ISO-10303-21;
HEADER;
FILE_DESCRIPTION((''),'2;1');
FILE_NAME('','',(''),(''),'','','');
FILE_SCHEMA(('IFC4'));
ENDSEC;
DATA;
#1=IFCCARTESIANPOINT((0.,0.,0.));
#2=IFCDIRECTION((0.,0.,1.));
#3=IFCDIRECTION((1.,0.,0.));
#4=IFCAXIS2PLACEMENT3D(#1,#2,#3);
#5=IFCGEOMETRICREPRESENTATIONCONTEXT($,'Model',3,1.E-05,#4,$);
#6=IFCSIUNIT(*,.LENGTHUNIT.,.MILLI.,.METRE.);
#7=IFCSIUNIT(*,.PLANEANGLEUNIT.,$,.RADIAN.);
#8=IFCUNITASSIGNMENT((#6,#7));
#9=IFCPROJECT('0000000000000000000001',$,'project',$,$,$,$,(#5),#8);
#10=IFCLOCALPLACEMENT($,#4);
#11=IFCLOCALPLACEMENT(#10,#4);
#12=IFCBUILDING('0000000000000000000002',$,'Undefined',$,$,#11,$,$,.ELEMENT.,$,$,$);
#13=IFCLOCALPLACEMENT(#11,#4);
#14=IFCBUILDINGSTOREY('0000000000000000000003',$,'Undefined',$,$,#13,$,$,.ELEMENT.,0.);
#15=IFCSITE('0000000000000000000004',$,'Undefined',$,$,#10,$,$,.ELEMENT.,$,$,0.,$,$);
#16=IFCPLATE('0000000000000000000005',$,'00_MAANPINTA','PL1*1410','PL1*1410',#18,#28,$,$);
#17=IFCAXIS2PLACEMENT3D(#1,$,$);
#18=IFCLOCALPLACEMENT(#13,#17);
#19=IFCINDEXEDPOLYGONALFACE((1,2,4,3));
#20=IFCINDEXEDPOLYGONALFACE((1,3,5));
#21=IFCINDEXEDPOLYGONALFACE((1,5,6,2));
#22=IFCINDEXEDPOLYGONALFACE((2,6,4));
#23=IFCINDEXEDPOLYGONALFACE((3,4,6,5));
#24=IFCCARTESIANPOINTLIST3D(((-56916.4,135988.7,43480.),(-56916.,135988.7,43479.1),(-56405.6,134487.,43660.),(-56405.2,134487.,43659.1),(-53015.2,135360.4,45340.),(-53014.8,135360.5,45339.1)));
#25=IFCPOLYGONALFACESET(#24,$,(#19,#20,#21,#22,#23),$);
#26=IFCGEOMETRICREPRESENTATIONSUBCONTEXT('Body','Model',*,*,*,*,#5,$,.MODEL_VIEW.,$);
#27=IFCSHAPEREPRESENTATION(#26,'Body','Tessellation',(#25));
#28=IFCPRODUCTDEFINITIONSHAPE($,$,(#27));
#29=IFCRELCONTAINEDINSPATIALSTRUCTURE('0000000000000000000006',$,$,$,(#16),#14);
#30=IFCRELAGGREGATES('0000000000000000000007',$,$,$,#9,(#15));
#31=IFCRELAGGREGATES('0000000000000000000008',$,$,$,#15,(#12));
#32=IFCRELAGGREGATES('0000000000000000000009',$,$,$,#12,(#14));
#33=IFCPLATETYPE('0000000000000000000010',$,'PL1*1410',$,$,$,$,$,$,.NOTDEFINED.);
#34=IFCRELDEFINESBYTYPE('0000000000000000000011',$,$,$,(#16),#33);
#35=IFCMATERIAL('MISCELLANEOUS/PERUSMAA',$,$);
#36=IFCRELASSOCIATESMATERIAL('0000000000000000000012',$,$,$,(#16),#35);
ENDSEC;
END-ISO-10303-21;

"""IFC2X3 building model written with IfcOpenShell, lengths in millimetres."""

from ifc_helpers import new_model, si_unit, frame, origin_with_axes, place, context, subcontext, project, spatial, polyline, outline, extrude, material, type_object, element, save


model = new_model("IFC2X3")

# Units and contexts
model_context = context("Model", 3, precision=1e-05, world=origin_with_axes())
body_context = subcontext(model_context, "Body", "Model", "MODEL_VIEW")
ifc_project = project(units=[si_unit("LENGTHUNIT", "METRE", prefix="MILLI"), si_unit("PLANEANGLEUNIT", "RADIAN")], contexts=[model_context])

# Site, building, storey
site_placement = place(None, origin_with_axes())
site = spatial("IfcSite", under=ifc_project, at=site_placement, Name="Undefined", CompositionType="ELEMENT", RefElevation=0.0)
building_placement = place(site_placement, origin_with_axes())
building = spatial("IfcBuilding", under=site, at=building_placement, Name="Undefined", CompositionType="ELEMENT")
storey_placement = place(building_placement, origin_with_axes())
storey = spatial("IfcBuildingStorey", under=building, at=storey_placement, Name="Undefined", CompositionType="ELEMENT", Elevation=0.0)

# Plate
ifc_material = material(Name="MISCELLANEOUS/PERUSMAA")
plate_type_1 = type_object("IfcPlateType", Name="PL1*1410", PredefinedType="NOTDEFINED")
plate_1_placement = place(storey_placement, frame((-53015.0, 135360.5, 45339.6), z_axis=(0.435296, 0.040266, -0.899387), x_axis=(-0.873065, -0.224926, -0.432626)))
element("IfcPlate", 1, at=plate_1_placement, inside=storey, type_object=plate_type_1, material=ifc_material, Name="00_MAANPINTA", Description="PL1*1410", ObjectType="PL1*1410", context=body_context, shape_type="SweptSolid", body=[
    extrude(outline(polyline([(0.0, 0.0), (3883.3, 0.0), (4069.3, 1585.5), (0.0, 0.0)])), frame((0.0, 0.0, -0.5), z_axis=(0.0, 0.0, 1.0), x_axis=(1.0, 0.0, 0.0)), (0.0, 0.0, 1.0), 1.0),
])

save(model, "model.ifc")
